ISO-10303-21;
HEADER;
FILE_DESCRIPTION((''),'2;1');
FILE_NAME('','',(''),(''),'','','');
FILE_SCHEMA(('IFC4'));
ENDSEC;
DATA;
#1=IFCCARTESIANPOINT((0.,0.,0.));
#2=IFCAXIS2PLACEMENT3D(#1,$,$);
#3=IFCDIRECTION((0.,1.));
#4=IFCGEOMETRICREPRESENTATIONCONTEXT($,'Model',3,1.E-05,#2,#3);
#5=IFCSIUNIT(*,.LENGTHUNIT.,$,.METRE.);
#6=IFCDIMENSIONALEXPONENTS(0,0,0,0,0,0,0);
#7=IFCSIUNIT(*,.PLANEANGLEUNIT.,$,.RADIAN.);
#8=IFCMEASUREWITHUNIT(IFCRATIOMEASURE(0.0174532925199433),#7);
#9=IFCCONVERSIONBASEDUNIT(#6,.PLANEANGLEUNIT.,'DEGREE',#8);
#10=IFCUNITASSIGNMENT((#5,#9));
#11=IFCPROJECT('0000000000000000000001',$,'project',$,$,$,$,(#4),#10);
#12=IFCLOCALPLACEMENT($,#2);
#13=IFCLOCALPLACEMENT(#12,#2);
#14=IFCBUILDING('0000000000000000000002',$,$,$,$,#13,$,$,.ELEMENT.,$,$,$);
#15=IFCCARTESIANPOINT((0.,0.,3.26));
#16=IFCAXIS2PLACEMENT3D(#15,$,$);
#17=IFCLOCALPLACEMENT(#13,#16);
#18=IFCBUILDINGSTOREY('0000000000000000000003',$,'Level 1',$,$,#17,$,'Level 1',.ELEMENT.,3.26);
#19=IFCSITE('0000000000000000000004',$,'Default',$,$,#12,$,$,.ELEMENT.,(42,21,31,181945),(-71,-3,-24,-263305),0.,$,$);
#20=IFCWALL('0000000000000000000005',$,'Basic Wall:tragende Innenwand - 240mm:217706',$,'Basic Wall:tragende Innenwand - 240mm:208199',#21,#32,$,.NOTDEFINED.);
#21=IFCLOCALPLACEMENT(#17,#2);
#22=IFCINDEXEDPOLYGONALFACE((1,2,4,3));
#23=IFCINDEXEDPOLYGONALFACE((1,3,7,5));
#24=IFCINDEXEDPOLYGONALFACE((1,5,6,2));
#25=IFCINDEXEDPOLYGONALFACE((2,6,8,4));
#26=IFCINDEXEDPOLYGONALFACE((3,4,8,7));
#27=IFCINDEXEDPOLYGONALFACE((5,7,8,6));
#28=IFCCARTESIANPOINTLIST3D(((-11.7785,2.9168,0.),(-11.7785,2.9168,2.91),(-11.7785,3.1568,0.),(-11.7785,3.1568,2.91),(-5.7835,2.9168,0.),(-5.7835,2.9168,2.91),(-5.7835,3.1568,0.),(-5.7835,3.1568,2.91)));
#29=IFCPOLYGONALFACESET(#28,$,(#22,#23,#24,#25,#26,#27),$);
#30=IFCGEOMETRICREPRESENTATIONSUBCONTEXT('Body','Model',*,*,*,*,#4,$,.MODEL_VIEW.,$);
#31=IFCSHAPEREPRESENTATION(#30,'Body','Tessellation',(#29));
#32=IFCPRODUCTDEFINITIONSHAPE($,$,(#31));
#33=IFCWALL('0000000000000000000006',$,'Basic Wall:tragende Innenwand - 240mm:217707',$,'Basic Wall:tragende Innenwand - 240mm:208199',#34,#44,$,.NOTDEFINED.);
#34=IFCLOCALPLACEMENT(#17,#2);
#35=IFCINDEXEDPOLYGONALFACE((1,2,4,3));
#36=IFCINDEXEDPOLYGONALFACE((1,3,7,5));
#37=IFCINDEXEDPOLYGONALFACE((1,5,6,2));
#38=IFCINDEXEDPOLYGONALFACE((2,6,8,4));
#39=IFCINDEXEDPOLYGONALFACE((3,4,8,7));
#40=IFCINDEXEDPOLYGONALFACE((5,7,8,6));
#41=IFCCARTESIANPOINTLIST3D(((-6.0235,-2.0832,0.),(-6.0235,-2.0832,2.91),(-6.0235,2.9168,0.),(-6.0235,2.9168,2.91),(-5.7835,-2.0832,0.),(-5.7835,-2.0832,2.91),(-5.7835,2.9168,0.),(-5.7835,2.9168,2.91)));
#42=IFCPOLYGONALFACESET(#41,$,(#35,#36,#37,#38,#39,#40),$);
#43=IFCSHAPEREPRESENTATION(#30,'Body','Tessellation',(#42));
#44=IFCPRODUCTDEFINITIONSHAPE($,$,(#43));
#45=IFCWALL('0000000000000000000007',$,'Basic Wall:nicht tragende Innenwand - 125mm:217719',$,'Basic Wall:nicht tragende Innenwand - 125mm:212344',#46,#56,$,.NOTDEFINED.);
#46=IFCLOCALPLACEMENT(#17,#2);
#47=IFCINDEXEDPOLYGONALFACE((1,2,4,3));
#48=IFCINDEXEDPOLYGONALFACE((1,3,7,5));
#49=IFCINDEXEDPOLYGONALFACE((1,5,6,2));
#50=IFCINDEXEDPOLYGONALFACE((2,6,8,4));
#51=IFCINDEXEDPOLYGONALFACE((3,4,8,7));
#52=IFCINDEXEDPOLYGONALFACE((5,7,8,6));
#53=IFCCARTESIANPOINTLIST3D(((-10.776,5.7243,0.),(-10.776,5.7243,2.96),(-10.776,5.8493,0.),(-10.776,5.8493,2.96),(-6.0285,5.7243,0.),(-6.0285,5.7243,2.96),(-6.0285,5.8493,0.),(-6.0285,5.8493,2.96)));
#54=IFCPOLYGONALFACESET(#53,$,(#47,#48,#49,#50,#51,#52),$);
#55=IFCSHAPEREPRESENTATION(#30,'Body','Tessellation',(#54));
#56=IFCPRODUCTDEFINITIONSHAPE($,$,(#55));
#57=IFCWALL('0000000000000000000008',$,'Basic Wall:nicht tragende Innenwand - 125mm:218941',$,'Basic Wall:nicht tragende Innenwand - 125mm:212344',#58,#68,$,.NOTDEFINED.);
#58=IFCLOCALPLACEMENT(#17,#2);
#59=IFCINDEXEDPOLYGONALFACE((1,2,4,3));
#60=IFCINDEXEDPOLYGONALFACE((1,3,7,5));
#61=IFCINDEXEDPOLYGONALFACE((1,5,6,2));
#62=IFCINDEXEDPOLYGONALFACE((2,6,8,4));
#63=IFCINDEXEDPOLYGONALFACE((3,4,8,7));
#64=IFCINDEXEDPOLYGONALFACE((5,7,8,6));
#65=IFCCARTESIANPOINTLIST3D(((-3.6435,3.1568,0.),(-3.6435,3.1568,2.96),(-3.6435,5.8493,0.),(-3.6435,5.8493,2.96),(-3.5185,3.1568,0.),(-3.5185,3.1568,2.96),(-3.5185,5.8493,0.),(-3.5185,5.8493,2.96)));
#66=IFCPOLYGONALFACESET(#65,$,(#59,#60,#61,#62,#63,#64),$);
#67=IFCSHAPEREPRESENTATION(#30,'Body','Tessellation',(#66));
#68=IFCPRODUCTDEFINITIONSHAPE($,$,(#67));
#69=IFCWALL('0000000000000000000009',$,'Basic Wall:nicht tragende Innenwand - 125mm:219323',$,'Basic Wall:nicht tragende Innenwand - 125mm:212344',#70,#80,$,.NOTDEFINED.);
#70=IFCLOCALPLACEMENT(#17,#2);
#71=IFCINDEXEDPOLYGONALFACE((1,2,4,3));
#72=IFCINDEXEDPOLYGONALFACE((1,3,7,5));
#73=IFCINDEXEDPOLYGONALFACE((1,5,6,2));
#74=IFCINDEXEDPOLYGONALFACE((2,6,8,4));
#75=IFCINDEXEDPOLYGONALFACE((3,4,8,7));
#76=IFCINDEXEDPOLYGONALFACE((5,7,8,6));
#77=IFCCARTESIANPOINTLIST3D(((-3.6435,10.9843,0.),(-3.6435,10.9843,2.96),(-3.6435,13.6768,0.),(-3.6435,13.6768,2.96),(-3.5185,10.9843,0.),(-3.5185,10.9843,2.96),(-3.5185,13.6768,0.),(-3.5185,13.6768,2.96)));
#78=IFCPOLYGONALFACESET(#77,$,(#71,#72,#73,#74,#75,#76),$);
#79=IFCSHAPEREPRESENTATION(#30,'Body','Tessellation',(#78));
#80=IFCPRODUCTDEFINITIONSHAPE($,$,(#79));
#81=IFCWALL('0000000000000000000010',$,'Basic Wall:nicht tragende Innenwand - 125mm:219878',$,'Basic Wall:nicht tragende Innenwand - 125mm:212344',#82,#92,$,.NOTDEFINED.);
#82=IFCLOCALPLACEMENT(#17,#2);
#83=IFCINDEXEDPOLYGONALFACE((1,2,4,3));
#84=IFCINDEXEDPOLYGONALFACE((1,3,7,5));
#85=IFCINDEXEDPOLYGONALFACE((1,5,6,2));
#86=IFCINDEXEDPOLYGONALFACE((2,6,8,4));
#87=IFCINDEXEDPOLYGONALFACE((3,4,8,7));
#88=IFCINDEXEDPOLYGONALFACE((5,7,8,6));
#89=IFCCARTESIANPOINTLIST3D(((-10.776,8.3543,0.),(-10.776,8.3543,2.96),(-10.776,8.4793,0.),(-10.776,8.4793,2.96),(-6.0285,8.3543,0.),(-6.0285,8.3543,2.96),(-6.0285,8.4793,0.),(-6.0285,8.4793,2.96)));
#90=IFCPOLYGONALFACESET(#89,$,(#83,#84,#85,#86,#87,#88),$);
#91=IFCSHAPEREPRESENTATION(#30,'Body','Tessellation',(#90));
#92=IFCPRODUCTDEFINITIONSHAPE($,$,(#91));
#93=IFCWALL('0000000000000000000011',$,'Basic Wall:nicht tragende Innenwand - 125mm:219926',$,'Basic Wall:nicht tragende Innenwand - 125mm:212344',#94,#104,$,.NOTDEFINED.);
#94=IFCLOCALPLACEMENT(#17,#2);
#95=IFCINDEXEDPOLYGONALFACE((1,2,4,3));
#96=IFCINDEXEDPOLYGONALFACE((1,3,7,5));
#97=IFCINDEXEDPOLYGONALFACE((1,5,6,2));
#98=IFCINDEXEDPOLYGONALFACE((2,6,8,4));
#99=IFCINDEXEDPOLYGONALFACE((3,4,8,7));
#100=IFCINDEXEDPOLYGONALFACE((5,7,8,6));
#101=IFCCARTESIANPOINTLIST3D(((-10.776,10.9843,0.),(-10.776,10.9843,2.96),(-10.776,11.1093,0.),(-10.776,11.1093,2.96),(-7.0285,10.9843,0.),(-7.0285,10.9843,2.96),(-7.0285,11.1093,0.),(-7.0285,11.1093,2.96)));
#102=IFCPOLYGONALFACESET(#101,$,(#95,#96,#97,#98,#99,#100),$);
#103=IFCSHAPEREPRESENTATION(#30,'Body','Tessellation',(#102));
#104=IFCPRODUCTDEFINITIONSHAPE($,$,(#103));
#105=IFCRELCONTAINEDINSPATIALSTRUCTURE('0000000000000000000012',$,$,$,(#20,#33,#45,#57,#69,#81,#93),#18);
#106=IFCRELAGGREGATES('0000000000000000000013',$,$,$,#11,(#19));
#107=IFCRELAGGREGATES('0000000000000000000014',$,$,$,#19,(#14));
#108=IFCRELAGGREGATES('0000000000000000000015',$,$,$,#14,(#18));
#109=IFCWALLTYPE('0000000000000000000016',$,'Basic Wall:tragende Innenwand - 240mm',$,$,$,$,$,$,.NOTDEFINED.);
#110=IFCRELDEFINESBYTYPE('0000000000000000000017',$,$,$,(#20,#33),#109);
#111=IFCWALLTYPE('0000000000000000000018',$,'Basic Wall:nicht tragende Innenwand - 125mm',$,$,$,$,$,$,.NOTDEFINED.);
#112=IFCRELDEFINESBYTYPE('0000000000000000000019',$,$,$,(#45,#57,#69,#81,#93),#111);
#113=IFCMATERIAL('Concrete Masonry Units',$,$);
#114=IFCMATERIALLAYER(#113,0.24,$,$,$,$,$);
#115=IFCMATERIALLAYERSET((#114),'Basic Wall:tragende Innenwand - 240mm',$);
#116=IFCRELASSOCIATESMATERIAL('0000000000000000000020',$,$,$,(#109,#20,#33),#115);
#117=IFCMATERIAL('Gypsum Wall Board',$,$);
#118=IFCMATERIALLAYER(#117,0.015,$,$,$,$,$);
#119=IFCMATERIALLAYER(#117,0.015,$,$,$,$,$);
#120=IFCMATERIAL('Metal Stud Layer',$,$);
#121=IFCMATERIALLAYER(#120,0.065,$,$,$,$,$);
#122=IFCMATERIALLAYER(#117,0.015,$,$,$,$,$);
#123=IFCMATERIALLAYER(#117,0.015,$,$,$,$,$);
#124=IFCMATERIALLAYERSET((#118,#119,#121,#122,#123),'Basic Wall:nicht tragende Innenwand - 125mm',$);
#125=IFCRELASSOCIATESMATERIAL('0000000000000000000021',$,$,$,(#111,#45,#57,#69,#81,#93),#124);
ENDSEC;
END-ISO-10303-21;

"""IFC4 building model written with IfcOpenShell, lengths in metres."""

from ifc_helpers import new_model, entity, si_unit, converted_unit, direction, frame, frame_2d, origin, place, context, subcontext, project, spatial, rectangle, extrude, material, layer, layer_set, layer_usage, type_object, element, save


model = new_model("IFC4")

# Units and contexts
model_context = context("Model", 3, precision=1e-05, world=origin(), true_north=direction((0.0, 1.0)))
body_context = subcontext(model_context, "Body", "Model", "MODEL_VIEW")
ifc_project = project(units=[si_unit("LENGTHUNIT", "METRE"), converted_unit("PLANEANGLEUNIT", "DEGREE", entity("IfcRatioMeasure", 0.0174532925199433), si_unit("PLANEANGLEUNIT", "RADIAN"), dimensions=[0, 0, 0, 0, 0, 0, 0])], contexts=[model_context])

# Site, building, storey
site_placement = place(None, origin())
site = spatial("IfcSite", under=ifc_project, at=site_placement, Name="Default", CompositionType="ELEMENT", RefLatitude=(42, 21, 31, 181945), RefLongitude=(-71, -3, -24, -263305), RefElevation=0.0)
building_placement = place(site_placement, origin())
building = spatial("IfcBuilding", under=site, at=building_placement, CompositionType="ELEMENT")
storey_placement = place(building_placement, frame((0.0, 0.0, 3.26)))
storey = spatial("IfcBuildingStorey", under=building, at=storey_placement, Name="Level 1", LongName="Level 1", CompositionType="ELEMENT", Elevation=3.26)

# Walls
ifc_material_1 = material(Name="Concrete Masonry Units")
ifc_layer_1 = layer(ifc_material_1, 0.24)
ifc_layer_set_1 = layer_set([ifc_layer_1], Name="Basic Wall:tragende Innenwand - 240mm")
ifc_layer_usage_1 = layer_usage(ifc_layer_set_1, "AXIS2", "NEGATIVE", 0.12)
wall_type_1 = type_object("IfcWallType", Name="Basic Wall:tragende Innenwand - 240mm", PredefinedType="NOTDEFINED", material=ifc_layer_set_1)
wall_1_placement = place(storey_placement, frame((-11.7785, 3.0368, 0.0)))
element("IfcWall", 1, at=wall_1_placement, inside=storey, type_object=wall_type_1, material=ifc_layer_usage_1, Name="Basic Wall:tragende Innenwand - 240mm:217706", ObjectType="Basic Wall:tragende Innenwand - 240mm:208199", PredefinedType="NOTDEFINED", context=body_context, shape_type="SweptSolid", body=[
    extrude(rectangle(XDim=5.995, YDim=0.24, at=frame_2d((2.9975, 0.0), x_axis=(-1.0, 0.0))), origin(), (0.0, 0.0, 1.0), 2.91),
])
ifc_layer_usage_2 = layer_usage(ifc_layer_set_1, "AXIS2", "NEGATIVE", 0.12)
wall_2_placement = place(storey_placement, frame((-5.9035, 2.9168, 0.0), z_axis=(0.0, 0.0, 1.0), x_axis=(0.0, -1.0, 0.0)))
element("IfcWall", 2, at=wall_2_placement, inside=storey, type_object=wall_type_1, material=ifc_layer_usage_2, Name="Basic Wall:tragende Innenwand - 240mm:217707", ObjectType="Basic Wall:tragende Innenwand - 240mm:208199", PredefinedType="NOTDEFINED", context=body_context, shape_type="SweptSolid", body=[
    extrude(rectangle(XDim=5.0, YDim=0.24, at=frame_2d((2.5, 0.0), x_axis=(-1.0, 0.0))), origin(), (0.0, 0.0, 1.0), 2.91),
])
ifc_material_2 = material(Name="Gypsum Wall Board")
ifc_layer_2 = layer(ifc_material_2, 0.015)
ifc_layer_3 = layer(ifc_material_2, 0.015)
ifc_material_3 = material(Name="Metal Stud Layer")
ifc_layer_4 = layer(ifc_material_3, 0.065)
ifc_layer_5 = layer(ifc_material_2, 0.015)
ifc_layer_6 = layer(ifc_material_2, 0.015)
ifc_layer_set_2 = layer_set([ifc_layer_2, ifc_layer_3, ifc_layer_4, ifc_layer_5, ifc_layer_6], Name="Basic Wall:nicht tragende Innenwand - 125mm")
ifc_layer_usage_3 = layer_usage(ifc_layer_set_2, "AXIS2", "NEGATIVE", 0.0625)
wall_type_2 = type_object("IfcWallType", Name="Basic Wall:nicht tragende Innenwand - 125mm", PredefinedType="NOTDEFINED", material=ifc_layer_set_2)
wall_3_placement = place(storey_placement, frame((-6.0285, 5.7868, 0.0), z_axis=(0.0, 0.0, 1.0), x_axis=(-1.0, 0.0, 0.0)))
element("IfcWall", 3, at=wall_3_placement, inside=storey, type_object=wall_type_2, material=ifc_layer_usage_3, Name="Basic Wall:nicht tragende Innenwand - 125mm:217719", ObjectType="Basic Wall:nicht tragende Innenwand - 125mm:212344", PredefinedType="NOTDEFINED", context=body_context, shape_type="SweptSolid", body=[
    extrude(rectangle(XDim=4.7475, YDim=0.125, at=frame_2d((2.3737, 0.0), x_axis=(-1.0, 0.0))), origin(), (0.0, 0.0, 1.0), 2.96),
])
ifc_layer_usage_4 = layer_usage(ifc_layer_set_2, "AXIS2", "POSITIVE", -0.0625)
wall_4_placement = place(storey_placement, frame((-3.581, 5.8493, 0.0), z_axis=(0.0, 0.0, 1.0), x_axis=(0.0, -1.0, 0.0)))
element("IfcWall", 4, at=wall_4_placement, inside=storey, type_object=wall_type_2, material=ifc_layer_usage_4, Name="Basic Wall:nicht tragende Innenwand - 125mm:218941", ObjectType="Basic Wall:nicht tragende Innenwand - 125mm:212344", PredefinedType="NOTDEFINED", context=body_context, shape_type="SweptSolid", body=[
    extrude(rectangle(XDim=2.6925, YDim=0.125, at=frame_2d((1.3462, 0.0), x_axis=(-1.0, 0.0))), origin(), (0.0, 0.0, 1.0), 2.96),
])
ifc_layer_usage_5 = layer_usage(ifc_layer_set_2, "AXIS2", "NEGATIVE", 0.0625)
wall_5_placement = place(storey_placement, frame((-3.581, 10.9843, 0.0), z_axis=(0.0, 0.0, 1.0), x_axis=(0.0, 1.0, 0.0)))
element("IfcWall", 5, at=wall_5_placement, inside=storey, type_object=wall_type_2, material=ifc_layer_usage_5, Name="Basic Wall:nicht tragende Innenwand - 125mm:219323", ObjectType="Basic Wall:nicht tragende Innenwand - 125mm:212344", PredefinedType="NOTDEFINED", context=body_context, shape_type="SweptSolid", body=[
    extrude(rectangle(XDim=2.6925, YDim=0.125, at=frame_2d((1.3462, 0.0), x_axis=(-1.0, 0.0))), origin(), (0.0, 0.0, 1.0), 2.96),
])
ifc_layer_usage_6 = layer_usage(ifc_layer_set_2, "AXIS2", "NEGATIVE", 0.0625)
wall_6_placement = place(storey_placement, frame((-6.0285, 8.4168, 0.0), z_axis=(0.0, 0.0, 1.0), x_axis=(-1.0, 0.0, 0.0)))
element("IfcWall", 6, at=wall_6_placement, inside=storey, type_object=wall_type_2, material=ifc_layer_usage_6, Name="Basic Wall:nicht tragende Innenwand - 125mm:219878", ObjectType="Basic Wall:nicht tragende Innenwand - 125mm:212344", PredefinedType="NOTDEFINED", context=body_context, shape_type="SweptSolid", body=[
    extrude(rectangle(XDim=4.7475, YDim=0.125, at=frame_2d((2.3737, 0.0), x_axis=(-1.0, 0.0))), origin(), (0.0, 0.0, 1.0), 2.96),
])
ifc_layer_usage_7 = layer_usage(ifc_layer_set_2, "AXIS2", "NEGATIVE", 0.0625)
wall_7_placement = place(storey_placement, frame((-7.0285, 11.0468, 0.0), z_axis=(0.0, 0.0, 1.0), x_axis=(-1.0, 0.0, 0.0)))
element("IfcWall", 7, at=wall_7_placement, inside=storey, type_object=wall_type_2, material=ifc_layer_usage_7, Name="Basic Wall:nicht tragende Innenwand - 125mm:219926", ObjectType="Basic Wall:nicht tragende Innenwand - 125mm:212344", PredefinedType="NOTDEFINED", context=body_context, shape_type="SweptSolid", body=[
    extrude(rectangle(XDim=3.7475, YDim=0.125, at=frame_2d((1.8738, 0.0), x_axis=(-1.0, 0.0))), origin(), (0.0, 0.0, 1.0), 2.96),
])

save(model, "model.ifc")
